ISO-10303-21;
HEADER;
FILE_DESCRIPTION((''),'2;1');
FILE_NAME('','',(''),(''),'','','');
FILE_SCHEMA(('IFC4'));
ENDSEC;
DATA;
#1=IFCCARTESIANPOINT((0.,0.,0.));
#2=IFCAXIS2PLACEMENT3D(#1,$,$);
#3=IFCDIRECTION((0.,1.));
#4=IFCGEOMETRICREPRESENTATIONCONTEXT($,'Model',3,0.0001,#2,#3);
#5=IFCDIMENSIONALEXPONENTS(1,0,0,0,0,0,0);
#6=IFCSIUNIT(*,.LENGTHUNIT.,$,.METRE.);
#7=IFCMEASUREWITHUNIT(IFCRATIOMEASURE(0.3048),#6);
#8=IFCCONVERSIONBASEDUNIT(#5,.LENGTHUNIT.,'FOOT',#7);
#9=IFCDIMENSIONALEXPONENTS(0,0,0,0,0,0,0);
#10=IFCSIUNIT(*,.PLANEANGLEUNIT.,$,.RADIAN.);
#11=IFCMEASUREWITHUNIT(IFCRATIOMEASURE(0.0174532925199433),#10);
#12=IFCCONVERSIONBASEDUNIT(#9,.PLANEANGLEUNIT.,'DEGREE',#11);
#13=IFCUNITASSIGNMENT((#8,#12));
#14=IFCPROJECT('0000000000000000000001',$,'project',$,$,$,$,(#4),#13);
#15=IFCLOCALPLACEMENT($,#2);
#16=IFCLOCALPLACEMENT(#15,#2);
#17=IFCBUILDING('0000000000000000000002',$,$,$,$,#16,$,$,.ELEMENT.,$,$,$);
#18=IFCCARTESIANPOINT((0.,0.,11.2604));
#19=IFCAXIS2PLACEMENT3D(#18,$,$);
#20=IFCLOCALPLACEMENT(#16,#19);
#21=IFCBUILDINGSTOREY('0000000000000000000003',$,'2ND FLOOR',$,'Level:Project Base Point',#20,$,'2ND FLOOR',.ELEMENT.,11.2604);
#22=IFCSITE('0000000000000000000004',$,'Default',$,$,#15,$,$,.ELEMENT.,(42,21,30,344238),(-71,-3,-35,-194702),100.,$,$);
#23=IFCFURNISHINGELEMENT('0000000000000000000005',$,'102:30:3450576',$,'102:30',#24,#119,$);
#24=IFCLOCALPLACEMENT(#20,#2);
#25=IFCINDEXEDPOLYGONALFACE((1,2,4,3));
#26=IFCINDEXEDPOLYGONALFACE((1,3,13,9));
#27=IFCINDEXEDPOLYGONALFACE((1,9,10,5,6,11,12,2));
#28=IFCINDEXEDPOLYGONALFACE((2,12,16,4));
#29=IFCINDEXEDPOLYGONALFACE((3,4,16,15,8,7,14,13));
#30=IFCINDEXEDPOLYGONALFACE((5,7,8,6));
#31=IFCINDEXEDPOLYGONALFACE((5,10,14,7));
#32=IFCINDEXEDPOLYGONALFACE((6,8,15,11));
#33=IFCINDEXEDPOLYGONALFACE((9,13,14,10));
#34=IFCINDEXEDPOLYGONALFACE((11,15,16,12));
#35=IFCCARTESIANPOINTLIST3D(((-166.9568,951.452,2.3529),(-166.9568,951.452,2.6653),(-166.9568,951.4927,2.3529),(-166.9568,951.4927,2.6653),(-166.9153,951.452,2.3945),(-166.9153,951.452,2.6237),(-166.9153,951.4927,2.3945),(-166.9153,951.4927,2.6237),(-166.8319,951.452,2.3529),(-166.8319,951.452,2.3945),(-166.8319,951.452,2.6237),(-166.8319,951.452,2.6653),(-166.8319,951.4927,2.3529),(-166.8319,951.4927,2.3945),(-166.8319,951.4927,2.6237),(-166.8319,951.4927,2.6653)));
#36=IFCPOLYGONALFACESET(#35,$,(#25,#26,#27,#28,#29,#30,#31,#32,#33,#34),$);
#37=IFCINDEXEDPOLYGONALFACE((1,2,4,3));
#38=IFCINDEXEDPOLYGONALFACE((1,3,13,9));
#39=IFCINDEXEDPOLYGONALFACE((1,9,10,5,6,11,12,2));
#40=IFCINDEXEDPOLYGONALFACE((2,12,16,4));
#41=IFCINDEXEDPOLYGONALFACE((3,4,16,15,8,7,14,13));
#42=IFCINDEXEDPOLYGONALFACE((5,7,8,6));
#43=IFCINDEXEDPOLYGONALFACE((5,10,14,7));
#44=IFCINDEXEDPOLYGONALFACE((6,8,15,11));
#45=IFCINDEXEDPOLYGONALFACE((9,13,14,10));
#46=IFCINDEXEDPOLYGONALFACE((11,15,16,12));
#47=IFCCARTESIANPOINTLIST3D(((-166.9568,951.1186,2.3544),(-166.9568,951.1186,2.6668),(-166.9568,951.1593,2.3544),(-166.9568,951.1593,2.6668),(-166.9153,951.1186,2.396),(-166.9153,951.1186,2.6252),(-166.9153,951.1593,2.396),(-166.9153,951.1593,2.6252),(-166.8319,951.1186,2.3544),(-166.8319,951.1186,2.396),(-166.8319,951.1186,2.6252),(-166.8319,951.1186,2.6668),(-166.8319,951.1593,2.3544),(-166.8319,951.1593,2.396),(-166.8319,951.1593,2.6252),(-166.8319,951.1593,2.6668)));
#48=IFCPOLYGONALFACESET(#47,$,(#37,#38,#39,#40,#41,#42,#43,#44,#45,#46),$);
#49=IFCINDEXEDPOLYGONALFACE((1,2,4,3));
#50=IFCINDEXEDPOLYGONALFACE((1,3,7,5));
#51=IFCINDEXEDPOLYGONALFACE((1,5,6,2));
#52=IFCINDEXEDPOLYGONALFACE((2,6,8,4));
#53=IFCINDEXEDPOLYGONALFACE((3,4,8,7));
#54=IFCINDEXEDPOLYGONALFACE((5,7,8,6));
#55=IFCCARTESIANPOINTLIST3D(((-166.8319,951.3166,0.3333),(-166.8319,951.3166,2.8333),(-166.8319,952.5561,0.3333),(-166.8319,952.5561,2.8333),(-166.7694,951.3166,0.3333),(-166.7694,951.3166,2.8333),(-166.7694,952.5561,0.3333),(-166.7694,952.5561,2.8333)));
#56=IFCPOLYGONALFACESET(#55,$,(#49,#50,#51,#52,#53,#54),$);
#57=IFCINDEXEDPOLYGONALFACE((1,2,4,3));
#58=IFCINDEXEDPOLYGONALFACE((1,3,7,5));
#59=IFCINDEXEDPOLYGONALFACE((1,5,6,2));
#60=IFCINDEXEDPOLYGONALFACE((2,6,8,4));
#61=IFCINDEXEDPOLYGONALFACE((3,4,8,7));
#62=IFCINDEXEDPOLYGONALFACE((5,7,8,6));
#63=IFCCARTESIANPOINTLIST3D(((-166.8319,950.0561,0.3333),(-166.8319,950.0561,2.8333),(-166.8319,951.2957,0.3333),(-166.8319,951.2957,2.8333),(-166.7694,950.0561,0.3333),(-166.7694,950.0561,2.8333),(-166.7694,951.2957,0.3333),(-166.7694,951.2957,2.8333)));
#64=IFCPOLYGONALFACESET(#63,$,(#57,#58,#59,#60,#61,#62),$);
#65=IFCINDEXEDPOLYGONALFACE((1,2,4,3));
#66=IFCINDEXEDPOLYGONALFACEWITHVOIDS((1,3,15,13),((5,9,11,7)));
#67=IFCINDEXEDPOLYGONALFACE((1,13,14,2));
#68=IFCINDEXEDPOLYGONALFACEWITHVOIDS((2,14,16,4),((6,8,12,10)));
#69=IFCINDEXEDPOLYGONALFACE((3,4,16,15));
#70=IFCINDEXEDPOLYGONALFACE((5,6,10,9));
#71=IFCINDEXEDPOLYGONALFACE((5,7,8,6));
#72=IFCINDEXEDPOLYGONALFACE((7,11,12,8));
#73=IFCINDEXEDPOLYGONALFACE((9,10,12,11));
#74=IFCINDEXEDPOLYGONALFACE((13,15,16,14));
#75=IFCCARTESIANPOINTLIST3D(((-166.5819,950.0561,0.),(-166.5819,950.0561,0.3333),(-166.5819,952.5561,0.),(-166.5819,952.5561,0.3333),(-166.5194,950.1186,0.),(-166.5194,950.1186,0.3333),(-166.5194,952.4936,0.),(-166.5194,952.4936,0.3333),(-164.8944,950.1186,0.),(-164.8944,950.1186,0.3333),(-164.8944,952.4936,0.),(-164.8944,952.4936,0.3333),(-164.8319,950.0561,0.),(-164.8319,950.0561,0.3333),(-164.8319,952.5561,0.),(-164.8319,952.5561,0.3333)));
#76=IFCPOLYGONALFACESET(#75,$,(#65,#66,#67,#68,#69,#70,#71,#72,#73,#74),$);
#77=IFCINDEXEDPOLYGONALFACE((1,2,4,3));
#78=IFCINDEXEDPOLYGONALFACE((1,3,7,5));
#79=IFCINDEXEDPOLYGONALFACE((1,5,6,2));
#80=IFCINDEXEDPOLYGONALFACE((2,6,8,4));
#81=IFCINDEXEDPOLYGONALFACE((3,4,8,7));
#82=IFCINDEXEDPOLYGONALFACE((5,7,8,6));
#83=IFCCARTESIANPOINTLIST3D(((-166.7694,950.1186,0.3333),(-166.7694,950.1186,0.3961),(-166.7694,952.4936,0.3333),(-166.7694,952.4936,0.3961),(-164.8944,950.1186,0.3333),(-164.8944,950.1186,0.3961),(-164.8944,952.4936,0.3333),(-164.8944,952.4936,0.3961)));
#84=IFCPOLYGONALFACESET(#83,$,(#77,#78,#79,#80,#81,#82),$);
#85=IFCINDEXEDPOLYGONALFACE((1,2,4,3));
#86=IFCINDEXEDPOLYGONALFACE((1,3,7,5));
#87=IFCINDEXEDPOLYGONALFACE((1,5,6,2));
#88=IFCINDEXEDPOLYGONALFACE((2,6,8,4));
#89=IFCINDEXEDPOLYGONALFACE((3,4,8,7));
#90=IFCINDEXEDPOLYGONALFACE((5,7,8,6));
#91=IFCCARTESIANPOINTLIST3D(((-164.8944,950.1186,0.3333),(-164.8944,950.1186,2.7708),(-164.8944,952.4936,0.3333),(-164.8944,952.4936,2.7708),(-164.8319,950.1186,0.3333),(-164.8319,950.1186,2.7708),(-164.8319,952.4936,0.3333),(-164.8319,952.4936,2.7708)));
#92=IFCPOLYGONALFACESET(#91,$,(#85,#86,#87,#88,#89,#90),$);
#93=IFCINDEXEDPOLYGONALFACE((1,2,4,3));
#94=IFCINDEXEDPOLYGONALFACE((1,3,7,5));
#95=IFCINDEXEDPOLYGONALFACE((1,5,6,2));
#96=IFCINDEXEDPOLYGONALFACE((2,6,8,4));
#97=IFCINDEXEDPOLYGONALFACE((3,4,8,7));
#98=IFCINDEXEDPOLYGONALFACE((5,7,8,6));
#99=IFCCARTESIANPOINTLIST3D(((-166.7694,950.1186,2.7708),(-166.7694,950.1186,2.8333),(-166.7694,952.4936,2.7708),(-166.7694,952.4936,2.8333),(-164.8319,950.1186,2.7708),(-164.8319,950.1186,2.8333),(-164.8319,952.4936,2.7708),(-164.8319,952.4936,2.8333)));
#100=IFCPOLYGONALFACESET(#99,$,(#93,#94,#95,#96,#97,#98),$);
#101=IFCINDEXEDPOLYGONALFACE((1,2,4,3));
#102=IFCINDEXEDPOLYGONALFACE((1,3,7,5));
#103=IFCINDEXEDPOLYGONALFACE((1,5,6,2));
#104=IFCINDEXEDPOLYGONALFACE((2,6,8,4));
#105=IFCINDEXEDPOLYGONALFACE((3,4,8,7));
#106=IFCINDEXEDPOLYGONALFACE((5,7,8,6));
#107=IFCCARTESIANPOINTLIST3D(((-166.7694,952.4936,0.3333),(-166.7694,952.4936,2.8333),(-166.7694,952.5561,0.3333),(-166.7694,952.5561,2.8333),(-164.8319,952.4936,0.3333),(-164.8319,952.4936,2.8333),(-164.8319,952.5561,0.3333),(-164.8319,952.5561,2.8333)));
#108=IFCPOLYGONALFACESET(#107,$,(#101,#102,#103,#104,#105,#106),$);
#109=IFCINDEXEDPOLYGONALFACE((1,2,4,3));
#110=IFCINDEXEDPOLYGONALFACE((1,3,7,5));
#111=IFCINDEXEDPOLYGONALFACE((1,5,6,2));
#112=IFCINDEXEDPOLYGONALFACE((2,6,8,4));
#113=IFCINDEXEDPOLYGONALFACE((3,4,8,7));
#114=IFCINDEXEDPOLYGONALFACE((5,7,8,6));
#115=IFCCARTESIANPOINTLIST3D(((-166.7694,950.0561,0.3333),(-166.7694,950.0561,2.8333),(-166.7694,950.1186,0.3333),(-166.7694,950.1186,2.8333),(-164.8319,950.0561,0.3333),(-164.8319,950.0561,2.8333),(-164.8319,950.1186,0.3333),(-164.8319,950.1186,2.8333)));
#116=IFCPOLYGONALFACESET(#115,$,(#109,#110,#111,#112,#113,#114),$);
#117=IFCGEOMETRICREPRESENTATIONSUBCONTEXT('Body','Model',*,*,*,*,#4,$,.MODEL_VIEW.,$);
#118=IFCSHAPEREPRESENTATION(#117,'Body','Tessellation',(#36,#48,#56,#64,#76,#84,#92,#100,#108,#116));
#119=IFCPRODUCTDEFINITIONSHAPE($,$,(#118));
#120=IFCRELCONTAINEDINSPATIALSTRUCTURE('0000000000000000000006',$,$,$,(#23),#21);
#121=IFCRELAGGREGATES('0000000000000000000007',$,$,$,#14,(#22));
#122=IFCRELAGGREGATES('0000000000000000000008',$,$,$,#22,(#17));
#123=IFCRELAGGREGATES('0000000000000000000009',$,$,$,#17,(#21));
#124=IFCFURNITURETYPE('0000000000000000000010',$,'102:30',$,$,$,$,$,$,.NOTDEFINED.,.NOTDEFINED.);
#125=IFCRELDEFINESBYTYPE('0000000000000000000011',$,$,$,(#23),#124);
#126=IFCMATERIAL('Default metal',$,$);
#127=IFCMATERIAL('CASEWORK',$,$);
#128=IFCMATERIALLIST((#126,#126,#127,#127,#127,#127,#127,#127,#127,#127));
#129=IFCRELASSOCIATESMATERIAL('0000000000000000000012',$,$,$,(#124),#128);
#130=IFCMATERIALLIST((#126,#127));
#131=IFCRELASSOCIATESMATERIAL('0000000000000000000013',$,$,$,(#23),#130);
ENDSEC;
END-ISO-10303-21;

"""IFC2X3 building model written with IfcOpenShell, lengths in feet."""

from ifc_helpers import new_model, entity, si_unit, converted_unit, direction, frame, frame_2d, origin, origin_2d_with_axis, place, context, subcontext, project, spatial, polyline, rectangle, outline, extrude, source, transform, mapped, material, material_list, type_object, type_shapes, element, save


model = new_model("IFC2X3")

# Units and contexts
model_context = context("Model", 3, precision=0.0001, world=origin(), true_north=direction((0.0, 1.0)))
body_context = subcontext(model_context, "Body", "Model", "MODEL_VIEW")
ifc_project = project(units=[converted_unit("LENGTHUNIT", "FOOT", entity("IfcRatioMeasure", 0.3048), si_unit("LENGTHUNIT", "METRE"), dimensions=[1, 0, 0, 0, 0, 0, 0]), converted_unit("PLANEANGLEUNIT", "DEGREE", entity("IfcRatioMeasure", 0.0174532925199433), si_unit("PLANEANGLEUNIT", "RADIAN"), dimensions=[0, 0, 0, 0, 0, 0, 0])], contexts=[model_context])

# Site, building, storey
site_placement = place(None, origin())
site = spatial("IfcSite", under=ifc_project, at=site_placement, Name="Default", CompositionType="ELEMENT", RefLatitude=(42, 21, 30, 344238), RefLongitude=(-71, -3, -35, -194702), RefElevation=100.0)
building_placement = place(site_placement, origin())
building = spatial("IfcBuilding", under=site, at=building_placement, CompositionType="ELEMENT")
storey_placement = place(building_placement, frame((0.0, 0.0, 11.2604)))
storey = spatial("IfcBuildingStorey", under=building, at=storey_placement, Name="2ND FLOOR", ObjectType="Level:Project Base Point", LongName="2ND FLOOR", CompositionType="ELEMENT", Elevation=11.2604)

# Furnishing element
ifc_material_1 = material(Name="CASEWORK")
ifc_material_2 = material(Name="Default metal")
ifc_material_list_1 = material_list([ifc_material_2, ifc_material_1])
ifc_material_list_2 = material_list([ifc_material_2, ifc_material_2, ifc_material_1, ifc_material_1, ifc_material_1, ifc_material_1, ifc_material_1, ifc_material_1, ifc_material_1, ifc_material_1])
furniture_type_1 = type_object("IfcFurnitureType", Name="102:30", material=ifc_material_list_2)
shared_shape_1 = source(origin(), body_context, "Body", "SweptSolid", [
    extrude(outline(polyline([(-0.0521, -0.1146), (-0.0521, -0.1562), (0.0729, -0.1562), (0.0729, 0.1562), (-0.0521, 0.1562), (-0.0521, 0.1146), (0.0313, 0.1146), (0.0313, -0.1146), (-0.0521, -0.1146)])), frame((0.2073, 2.0521, 2.5091), z_axis=(-1.0, 0.0, 0.0), x_axis=(0.0, 1.0, 0.0)), (0.0, 0.0, -1.0), 0.0407),
    extrude(outline(polyline([(-0.0521, -0.1146), (-0.0521, -0.1562), (0.0729, -0.1562), (0.0729, 0.1562), (-0.0521, 0.1562), (-0.0521, 0.1146), (0.0313, 0.1146), (0.0313, -0.1146), (-0.0521, -0.1146)])), frame((-0.126, 2.0521, 2.5106), z_axis=(-1.0, 0.0, 0.0), x_axis=(0.0, 1.0, 0.0)), (0.0, 0.0, -1.0), 0.0407),
    extrude(rectangle(XDim=1.2396, YDim=0.0625, at=frame_2d((0.0, 0.0), x_axis=(1.0, 0.0))), frame((0.6917, 1.9688, 0.3333), z_axis=(0.0, 0.0, 1.0), x_axis=(-1.0, 0.0, 0.0)), (0.0, 0.0, 1.0), 2.5),
    extrude(rectangle(XDim=1.2396, YDim=0.0625, at=origin_2d_with_axis()), frame((-0.5687, 1.9688, 0.3333), z_axis=(0.0, 0.0, 1.0), x_axis=(-1.0, 0.0, 0.0)), (0.0, 0.0, 1.0), 2.5),
    extrude(outline(polyline([(-0.875, -1.25), (0.875, -1.25), (0.875, 1.25), (-0.875, 1.25), (-0.875, -1.25)]), holes=[polyline([(-0.8125, -1.1875), (-0.8125, 1.1875), (0.8125, 1.1875), (0.8125, -1.1875), (-0.8125, -1.1875)])]), frame((0.0615, 0.875, 0.0), z_axis=(0.0, 0.0, 1.0), x_axis=(0.0, -1.0, 0.0)), (0.0, 0.0, 1.0), 0.3333),
    extrude(rectangle(XDim=1.875, YDim=2.375, at=origin_2d_with_axis()), frame((0.0615, 1.0, 0.3333), z_axis=(0.0, 0.0, 1.0), x_axis=(0.0, 1.0, 0.0)), (0.0, 0.0, 1.0), 0.0627),
    extrude(rectangle(XDim=2.375, YDim=0.0625, at=origin_2d_with_axis()), frame((0.0615, 0.0312, 0.3333), z_axis=(0.0, 0.0, 1.0), x_axis=(-1.0, 0.0, 0.0)), (0.0, 0.0, 1.0), 2.4375),
    extrude(rectangle(XDim=1.9375, YDim=2.375, at=frame_2d((0.0, 0.0), x_axis=(1.0, 0.0))), frame((0.0615, 0.9688, 2.7708), z_axis=(0.0, 0.0, 1.0), x_axis=(0.0, 1.0, 0.0)), (0.0, 0.0, 1.0), 0.0625),
    extrude(rectangle(XDim=1.9375, YDim=0.0625, at=frame_2d((0.0, 0.0), x_axis=(1.0, 0.0))), frame((1.2802, 0.9687, 0.3333), z_axis=(0.0, 0.0, 1.0), x_axis=(0.0, -1.0, 0.0)), (0.0, 0.0, 1.0), 2.5),
    extrude(rectangle(XDim=1.9375, YDim=0.0625, at=frame_2d((0.0, 0.0), x_axis=(1.0, 0.0))), frame((-1.1573, 0.9687, 0.3333), z_axis=(0.0, 0.0, 1.0), x_axis=(0.0, -1.0, 0.0)), (0.0, 0.0, 1.0), 2.5),
])
type_shapes(furniture_type_1, [shared_shape_1])
furnishing_1_placement = place(storey_placement, frame((-164.8319, 951.2447, 0.0), z_axis=(0.0, 0.0, 1.0), x_axis=(0.0, 1.0, 0.0)))
element("IfcFurnishingElement", 1, at=furnishing_1_placement, inside=storey, type_object=furniture_type_1, material=ifc_material_list_1, Name="102:30:3450576", ObjectType="102:30", context=body_context, shape_type="MappedRepresentation", body=[
    mapped(shared_shape_1, transform((0.0, 0.0, 0.0), scale=1.0)),
])

save(model, "model.ifc")
